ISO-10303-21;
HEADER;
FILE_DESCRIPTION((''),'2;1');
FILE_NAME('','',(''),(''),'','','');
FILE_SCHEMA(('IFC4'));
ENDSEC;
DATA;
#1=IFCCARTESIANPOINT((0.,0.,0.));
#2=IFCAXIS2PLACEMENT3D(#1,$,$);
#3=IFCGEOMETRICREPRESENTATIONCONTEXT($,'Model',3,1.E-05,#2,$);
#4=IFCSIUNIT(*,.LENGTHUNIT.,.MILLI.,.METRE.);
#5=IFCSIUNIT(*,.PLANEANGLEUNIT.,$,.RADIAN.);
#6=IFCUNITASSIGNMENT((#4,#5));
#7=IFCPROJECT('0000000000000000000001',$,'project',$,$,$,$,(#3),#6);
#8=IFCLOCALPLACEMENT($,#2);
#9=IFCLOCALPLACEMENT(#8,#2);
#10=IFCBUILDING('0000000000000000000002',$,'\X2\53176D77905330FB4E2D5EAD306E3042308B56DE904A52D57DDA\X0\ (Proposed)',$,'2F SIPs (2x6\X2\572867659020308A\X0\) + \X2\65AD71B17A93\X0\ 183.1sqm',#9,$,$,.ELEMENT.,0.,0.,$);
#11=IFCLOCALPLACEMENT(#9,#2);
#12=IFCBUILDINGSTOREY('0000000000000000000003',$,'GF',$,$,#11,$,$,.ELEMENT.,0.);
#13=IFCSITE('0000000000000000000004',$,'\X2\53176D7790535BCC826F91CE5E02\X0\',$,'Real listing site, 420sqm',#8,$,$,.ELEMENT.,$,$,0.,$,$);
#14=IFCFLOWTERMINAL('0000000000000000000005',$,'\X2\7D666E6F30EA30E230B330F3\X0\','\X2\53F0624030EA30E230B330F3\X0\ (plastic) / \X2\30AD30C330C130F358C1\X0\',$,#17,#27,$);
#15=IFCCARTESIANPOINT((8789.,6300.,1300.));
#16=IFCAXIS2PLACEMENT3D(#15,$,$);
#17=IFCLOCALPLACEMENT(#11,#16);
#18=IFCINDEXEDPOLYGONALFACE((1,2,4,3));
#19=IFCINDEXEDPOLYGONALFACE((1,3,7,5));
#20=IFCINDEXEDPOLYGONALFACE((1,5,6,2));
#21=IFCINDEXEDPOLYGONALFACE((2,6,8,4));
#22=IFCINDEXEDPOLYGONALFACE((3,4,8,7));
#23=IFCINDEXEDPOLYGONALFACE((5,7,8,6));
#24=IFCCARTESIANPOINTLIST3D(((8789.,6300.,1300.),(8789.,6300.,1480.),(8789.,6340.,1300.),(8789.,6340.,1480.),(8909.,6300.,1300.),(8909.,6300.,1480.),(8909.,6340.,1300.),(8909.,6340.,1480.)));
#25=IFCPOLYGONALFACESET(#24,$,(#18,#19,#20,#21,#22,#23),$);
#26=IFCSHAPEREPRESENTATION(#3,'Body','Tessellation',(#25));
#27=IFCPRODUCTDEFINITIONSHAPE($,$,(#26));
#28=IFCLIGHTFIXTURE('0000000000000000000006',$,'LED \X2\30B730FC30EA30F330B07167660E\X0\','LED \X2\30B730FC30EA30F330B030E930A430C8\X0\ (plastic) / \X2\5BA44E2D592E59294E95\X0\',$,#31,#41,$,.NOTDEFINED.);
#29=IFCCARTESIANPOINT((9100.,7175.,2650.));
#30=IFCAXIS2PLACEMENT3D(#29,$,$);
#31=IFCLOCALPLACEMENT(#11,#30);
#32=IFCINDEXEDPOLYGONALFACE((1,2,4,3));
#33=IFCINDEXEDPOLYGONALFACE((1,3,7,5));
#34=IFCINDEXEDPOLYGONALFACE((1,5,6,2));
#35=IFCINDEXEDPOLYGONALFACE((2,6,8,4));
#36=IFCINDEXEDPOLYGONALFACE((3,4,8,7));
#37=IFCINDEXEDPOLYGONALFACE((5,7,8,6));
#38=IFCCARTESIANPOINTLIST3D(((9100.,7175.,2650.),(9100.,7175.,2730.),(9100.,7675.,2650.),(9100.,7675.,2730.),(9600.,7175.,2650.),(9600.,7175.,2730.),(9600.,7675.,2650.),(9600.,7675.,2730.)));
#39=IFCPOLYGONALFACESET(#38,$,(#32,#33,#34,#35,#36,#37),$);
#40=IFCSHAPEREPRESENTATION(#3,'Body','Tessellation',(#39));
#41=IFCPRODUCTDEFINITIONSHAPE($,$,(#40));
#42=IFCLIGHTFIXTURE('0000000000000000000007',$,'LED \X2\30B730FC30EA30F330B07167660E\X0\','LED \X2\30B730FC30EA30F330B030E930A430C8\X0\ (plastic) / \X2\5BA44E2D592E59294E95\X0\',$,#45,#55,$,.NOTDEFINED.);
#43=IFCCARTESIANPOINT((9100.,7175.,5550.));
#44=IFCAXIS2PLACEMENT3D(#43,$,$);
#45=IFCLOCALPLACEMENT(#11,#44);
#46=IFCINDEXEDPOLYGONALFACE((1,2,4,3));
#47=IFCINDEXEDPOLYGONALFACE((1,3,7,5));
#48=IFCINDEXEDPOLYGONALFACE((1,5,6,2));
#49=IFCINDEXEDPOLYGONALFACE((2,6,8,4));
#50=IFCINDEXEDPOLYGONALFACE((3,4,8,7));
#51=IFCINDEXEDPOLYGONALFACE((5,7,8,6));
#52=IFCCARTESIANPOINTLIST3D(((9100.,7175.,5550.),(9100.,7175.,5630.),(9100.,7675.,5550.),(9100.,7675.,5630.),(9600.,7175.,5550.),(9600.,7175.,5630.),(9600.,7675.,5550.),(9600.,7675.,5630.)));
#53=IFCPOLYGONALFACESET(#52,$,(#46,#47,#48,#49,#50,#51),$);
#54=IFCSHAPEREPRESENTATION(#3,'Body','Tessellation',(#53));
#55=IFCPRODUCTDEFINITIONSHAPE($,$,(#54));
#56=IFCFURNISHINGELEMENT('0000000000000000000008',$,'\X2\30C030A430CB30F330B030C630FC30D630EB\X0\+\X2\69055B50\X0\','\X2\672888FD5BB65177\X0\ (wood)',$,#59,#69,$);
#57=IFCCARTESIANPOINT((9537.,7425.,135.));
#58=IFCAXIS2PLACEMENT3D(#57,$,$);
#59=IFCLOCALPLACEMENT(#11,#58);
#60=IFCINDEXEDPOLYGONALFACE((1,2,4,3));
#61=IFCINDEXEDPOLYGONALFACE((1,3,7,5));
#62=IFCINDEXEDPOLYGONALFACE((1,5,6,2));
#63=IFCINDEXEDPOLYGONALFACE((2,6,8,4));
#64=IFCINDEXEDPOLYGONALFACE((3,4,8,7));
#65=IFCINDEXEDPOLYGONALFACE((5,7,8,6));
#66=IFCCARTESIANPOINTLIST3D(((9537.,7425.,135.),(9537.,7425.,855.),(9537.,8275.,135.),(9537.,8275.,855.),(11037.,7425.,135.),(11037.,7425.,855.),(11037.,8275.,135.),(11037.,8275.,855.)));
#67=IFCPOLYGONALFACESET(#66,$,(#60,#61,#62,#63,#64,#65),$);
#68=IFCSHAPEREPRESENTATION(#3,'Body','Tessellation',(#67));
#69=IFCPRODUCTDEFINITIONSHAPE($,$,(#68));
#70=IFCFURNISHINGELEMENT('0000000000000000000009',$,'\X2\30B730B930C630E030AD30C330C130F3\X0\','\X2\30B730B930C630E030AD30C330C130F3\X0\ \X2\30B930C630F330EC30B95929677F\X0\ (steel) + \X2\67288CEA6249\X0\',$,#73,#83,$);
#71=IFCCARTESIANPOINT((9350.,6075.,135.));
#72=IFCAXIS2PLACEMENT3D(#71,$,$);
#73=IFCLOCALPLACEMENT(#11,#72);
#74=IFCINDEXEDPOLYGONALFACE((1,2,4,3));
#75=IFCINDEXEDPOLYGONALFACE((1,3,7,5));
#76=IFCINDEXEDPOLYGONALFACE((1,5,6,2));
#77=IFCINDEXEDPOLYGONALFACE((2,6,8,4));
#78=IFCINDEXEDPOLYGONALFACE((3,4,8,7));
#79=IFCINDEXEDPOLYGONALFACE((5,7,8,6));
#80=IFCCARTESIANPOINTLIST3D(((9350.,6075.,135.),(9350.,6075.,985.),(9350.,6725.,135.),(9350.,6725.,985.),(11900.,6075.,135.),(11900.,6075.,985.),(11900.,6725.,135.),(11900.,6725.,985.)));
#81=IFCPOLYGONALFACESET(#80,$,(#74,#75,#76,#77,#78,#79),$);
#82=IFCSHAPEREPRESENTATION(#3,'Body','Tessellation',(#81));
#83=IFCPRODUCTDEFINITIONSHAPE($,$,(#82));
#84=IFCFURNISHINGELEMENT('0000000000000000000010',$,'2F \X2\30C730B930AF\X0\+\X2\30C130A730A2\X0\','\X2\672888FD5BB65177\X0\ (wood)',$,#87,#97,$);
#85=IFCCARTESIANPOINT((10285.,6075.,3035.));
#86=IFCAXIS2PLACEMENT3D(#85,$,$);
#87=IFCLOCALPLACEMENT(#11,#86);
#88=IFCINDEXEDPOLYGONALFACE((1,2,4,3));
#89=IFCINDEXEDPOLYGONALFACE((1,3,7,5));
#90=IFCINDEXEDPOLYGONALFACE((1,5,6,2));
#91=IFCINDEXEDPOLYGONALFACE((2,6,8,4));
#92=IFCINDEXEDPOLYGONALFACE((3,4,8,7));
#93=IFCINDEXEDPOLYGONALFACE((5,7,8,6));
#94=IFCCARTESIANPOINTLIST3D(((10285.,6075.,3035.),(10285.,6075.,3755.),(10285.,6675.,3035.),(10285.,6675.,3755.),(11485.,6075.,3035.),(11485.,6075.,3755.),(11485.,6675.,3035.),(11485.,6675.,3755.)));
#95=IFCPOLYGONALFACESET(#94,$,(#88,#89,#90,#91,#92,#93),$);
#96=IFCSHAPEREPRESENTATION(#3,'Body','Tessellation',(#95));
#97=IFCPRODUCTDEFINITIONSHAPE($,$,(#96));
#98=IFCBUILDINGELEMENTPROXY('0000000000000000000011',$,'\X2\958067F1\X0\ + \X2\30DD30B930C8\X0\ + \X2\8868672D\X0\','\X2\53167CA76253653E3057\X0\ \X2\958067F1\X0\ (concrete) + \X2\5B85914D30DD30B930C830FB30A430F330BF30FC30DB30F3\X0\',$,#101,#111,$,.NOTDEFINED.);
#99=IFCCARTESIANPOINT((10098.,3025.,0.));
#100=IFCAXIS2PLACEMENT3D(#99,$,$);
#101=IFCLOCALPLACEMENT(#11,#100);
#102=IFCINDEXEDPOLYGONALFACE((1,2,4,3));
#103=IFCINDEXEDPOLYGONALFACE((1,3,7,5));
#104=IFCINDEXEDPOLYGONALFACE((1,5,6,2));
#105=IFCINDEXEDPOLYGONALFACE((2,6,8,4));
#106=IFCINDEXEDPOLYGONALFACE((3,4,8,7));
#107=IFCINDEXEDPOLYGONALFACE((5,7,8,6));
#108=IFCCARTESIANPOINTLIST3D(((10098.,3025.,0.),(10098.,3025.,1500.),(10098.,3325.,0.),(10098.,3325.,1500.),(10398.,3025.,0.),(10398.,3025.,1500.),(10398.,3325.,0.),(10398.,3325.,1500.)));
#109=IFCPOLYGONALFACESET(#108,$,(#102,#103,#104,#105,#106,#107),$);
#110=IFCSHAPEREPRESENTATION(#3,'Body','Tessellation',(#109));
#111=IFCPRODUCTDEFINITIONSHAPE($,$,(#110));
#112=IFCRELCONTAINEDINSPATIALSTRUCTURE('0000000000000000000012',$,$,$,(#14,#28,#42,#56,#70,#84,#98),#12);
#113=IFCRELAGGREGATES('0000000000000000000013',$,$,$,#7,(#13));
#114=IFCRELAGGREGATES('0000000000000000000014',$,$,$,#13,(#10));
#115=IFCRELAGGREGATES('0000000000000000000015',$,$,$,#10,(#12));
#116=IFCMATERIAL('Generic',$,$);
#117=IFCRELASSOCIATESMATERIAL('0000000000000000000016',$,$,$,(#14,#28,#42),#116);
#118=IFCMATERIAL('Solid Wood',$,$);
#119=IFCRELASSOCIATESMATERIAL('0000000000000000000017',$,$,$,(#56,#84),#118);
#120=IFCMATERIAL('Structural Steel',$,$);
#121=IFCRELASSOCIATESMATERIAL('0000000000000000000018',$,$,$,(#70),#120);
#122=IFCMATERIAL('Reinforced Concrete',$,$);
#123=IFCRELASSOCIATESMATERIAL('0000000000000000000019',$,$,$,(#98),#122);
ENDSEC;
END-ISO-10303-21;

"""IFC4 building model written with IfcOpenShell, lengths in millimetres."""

from ifc_helpers import new_model, si_unit, frame, frame_2d, origin, place, context, project, spatial, rectangle, extrude, material, element, save


model = new_model("IFC4")

# Units and contexts
model_context = context("Model", 3, precision=1e-05, world=origin())
ifc_project = project(units=[si_unit("LENGTHUNIT", "METRE", prefix="MILLI"), si_unit("PLANEANGLEUNIT", "RADIAN")], contexts=[model_context])

# Site, building, storey
site_placement = place(None, origin())
site = spatial("IfcSite", under=ifc_project, at=site_placement, Name="北海道富良野市", ObjectType="Real listing site, 420sqm", CompositionType="ELEMENT", RefElevation=0.0)
building_placement = place(site_placement, origin())
building = spatial("IfcBuilding", under=site, at=building_placement, Name="北海道・中庭のある回遊動線 (Proposed)", ObjectType="2F SIPs (2x6在来造り) + 断熱窓 183.1sqm", CompositionType="ELEMENT", ElevationOfRefHeight=0.0, ElevationOfTerrain=0.0)
storey_placement = place(building_placement, origin())
storey = spatial("IfcBuildingStorey", under=building, at=storey_placement, Name="GF", CompositionType="ELEMENT", Elevation=0.0)

# Shared definitions
ifc_material_1 = material(Name="Solid Wood")

# Shared definitions
ifc_material_2 = material(Name="Structural Steel")

# Shared definitions
ifc_material_3 = material(Name="Reinforced Concrete")

# Flow terminal
ifc_material_4 = material(Name="Generic")
flow_terminal_1_placement = place(storey_placement, frame((8789.0, 6300.0, 1300.0)))
element("IfcFlowTerminal", 1, at=flow_terminal_1_placement, inside=storey, material=ifc_material_4, Name="給湯リモコン", Description="台所リモコン (plastic) / キッチン壁", context=model_context, shape_type="SweptSolid", body=[
    extrude(rectangle(XDim=120.0, YDim=40.0, at=frame_2d((60.0, 20.0))), frame((8789.0, 6300.0, 1300.0)), (0.0, 0.0, 1.0), 180.0),
])

# Light fixtures
light_fixture_1_placement = place(storey_placement, frame((9100.0, 7175.0, 2650.0)))
element("IfcLightFixture", 2, at=light_fixture_1_placement, inside=storey, material=ifc_material_4, Name="LED シーリング照明", Description="LED シーリングライト (plastic) / 室中央天井", PredefinedType="NOTDEFINED", context=model_context, shape_type="SweptSolid", body=[
    extrude(rectangle(XDim=500.0, YDim=500.0, at=frame_2d((250.0, 250.0))), frame((9100.0, 7175.0, 2650.0)), (0.0, 0.0, 1.0), 80.0),
])
light_fixture_2_placement = place(storey_placement, frame((9100.0, 7175.0, 5550.0)))
element("IfcLightFixture", 3, at=light_fixture_2_placement, inside=storey, material=ifc_material_4, Name="LED シーリング照明", Description="LED シーリングライト (plastic) / 室中央天井", PredefinedType="NOTDEFINED", context=model_context, shape_type="SweptSolid", body=[
    extrude(rectangle(XDim=500.0, YDim=500.0, at=frame_2d((250.0, 250.0))), frame((9100.0, 7175.0, 5550.0)), (0.0, 0.0, 1.0), 80.0),
])

# Furnishing elements
furnishing_1_placement = place(storey_placement, frame((9537.0, 7425.0, 135.0)))
element("IfcFurnishingElement", 4, at=furnishing_1_placement, inside=storey, material=ifc_material_1, Name="ダイニングテーブル+椅子", Description="木製家具 (wood)", context=model_context, shape_type="SweptSolid", body=[
    extrude(rectangle(XDim=1500.0, YDim=850.0, at=frame_2d((750.0, 425.0))), frame((9537.0, 7425.0, 135.0)), (0.0, 0.0, 1.0), 720.0),
])
furnishing_2_placement = place(storey_placement, frame((9350.0, 6075.0, 135.0)))
element("IfcFurnishingElement", 5, at=furnishing_2_placement, inside=storey, material=ifc_material_2, Name="システムキッチン", Description="システムキッチン ステンレス天板 (steel) + 木質扉", context=model_context, shape_type="SweptSolid", body=[
    extrude(rectangle(XDim=2550.0, YDim=650.0, at=frame_2d((1275.0, 325.0))), frame((9350.0, 6075.0, 135.0)), (0.0, 0.0, 1.0), 850.0),
])
furnishing_3_placement = place(storey_placement, frame((10285.0, 6075.0, 3035.0)))
element("IfcFurnishingElement", 6, at=furnishing_3_placement, inside=storey, material=ifc_material_1, Name="2F デスク+チェア", Description="木製家具 (wood)", context=model_context, shape_type="SweptSolid", body=[
    extrude(rectangle(XDim=1200.0, YDim=600.0, at=frame_2d((600.0, 300.0))), frame((10285.0, 6075.0, 3035.0)), (0.0, 0.0, 1.0), 720.0),
])

# Building element proxy
proxy_placement = place(storey_placement, frame((10098.0, 3025.0, 0.0)))
element("IfcBuildingElementProxy", 7, at=proxy_placement, inside=storey, material=ifc_material_3, Name="門柱 + ポスト + 表札", Description="化粧打放し 門柱 (concrete) + 宅配ポスト・インターホン", PredefinedType="NOTDEFINED", context=model_context, shape_type="SweptSolid", body=[
    extrude(rectangle(XDim=300.0, YDim=300.0, at=frame_2d((150.0, 150.0))), frame((10098.0, 3025.0, 0.0)), (0.0, 0.0, 1.0), 1500.0),
])

save(model, "model.ifc")
